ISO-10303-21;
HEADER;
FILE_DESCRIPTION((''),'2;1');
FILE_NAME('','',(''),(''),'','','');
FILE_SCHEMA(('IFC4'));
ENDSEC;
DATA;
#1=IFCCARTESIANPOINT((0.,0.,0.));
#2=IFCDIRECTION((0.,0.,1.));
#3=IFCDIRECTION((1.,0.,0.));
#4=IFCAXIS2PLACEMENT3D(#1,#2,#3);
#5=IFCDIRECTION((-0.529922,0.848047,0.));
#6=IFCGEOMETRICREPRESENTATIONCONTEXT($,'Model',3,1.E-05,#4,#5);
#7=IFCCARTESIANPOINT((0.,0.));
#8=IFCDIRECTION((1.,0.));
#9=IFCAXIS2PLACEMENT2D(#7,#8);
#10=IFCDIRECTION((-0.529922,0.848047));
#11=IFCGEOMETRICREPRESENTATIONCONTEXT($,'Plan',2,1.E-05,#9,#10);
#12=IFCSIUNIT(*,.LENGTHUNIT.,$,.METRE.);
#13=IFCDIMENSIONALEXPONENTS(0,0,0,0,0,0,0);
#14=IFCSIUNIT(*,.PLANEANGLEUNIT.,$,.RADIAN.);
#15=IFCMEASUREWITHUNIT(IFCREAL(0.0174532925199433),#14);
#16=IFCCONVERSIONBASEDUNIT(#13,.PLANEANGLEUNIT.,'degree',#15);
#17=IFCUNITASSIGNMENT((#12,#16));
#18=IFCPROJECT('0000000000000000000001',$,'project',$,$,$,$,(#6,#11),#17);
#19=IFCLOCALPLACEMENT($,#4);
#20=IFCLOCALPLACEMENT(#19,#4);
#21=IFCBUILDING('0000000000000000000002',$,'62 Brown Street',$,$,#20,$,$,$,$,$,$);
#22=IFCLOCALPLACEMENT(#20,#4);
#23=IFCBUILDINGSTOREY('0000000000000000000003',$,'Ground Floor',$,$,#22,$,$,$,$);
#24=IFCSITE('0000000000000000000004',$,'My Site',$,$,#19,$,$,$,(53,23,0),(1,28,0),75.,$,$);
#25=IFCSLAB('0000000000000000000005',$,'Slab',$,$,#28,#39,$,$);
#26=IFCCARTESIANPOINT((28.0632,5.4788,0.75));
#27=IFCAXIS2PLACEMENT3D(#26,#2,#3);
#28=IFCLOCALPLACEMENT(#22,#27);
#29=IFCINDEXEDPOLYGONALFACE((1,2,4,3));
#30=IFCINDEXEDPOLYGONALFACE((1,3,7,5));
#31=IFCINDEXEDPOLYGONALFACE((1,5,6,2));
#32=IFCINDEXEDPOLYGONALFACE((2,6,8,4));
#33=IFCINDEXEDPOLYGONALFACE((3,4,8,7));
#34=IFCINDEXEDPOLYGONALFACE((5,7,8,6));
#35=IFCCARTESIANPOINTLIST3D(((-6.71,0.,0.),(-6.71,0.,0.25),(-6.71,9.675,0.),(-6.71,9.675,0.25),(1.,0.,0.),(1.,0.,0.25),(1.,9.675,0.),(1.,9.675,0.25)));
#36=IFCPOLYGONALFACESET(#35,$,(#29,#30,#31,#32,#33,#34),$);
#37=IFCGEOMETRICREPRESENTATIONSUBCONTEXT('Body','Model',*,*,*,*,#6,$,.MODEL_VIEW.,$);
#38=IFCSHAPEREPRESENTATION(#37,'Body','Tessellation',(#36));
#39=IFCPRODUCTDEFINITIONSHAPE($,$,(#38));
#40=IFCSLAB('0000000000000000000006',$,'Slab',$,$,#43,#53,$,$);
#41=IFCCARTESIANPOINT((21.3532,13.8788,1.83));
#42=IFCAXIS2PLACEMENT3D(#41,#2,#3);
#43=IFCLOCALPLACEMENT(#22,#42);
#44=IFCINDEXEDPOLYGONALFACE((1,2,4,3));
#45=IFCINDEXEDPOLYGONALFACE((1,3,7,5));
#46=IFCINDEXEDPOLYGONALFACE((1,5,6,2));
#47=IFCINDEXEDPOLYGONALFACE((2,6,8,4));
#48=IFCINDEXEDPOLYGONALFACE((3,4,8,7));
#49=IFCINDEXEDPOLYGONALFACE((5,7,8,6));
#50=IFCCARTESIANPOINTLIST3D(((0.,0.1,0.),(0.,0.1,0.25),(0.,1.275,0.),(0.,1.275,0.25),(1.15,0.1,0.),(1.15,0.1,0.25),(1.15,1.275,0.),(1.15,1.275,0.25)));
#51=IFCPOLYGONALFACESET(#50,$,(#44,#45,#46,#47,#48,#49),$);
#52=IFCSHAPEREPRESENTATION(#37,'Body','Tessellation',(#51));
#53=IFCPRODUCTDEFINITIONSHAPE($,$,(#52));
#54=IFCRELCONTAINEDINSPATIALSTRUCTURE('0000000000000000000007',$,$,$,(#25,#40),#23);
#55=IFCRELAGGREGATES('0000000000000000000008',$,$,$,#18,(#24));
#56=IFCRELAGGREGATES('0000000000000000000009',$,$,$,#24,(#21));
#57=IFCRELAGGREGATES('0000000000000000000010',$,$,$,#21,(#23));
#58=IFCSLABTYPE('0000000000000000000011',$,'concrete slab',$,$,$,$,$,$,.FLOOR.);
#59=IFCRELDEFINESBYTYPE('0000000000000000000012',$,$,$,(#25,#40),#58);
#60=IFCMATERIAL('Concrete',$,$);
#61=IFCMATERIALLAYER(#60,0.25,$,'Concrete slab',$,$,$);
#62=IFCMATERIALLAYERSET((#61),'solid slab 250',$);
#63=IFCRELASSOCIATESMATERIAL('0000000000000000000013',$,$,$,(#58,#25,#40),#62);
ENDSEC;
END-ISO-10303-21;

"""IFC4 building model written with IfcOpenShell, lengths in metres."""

from ifc_helpers import new_model, entity, si_unit, converted_unit, direction, frame, origin_with_axes, origin_2d_with_axis, place, context, subcontext, project, spatial, indexed_curve, outline, extrude, material, layer, layer_set, layer_usage, type_object, element, save


model = new_model("IFC4")

# Units and contexts
model_context = context("Model", 3, precision=1e-05, world=origin_with_axes(), true_north=direction((-0.529922, 0.848047, 0.0)))
plan_context = context("Plan", 2, precision=1e-05, world=origin_2d_with_axis(), true_north=direction((-0.529922, 0.848047)))
body_context_1 = subcontext(model_context, "Body", "Model", "MODEL_VIEW")
ifc_project = project(units=[si_unit("LENGTHUNIT", "METRE"), converted_unit("PLANEANGLEUNIT", "degree", entity("IfcReal", 0.0174532925199433), si_unit("PLANEANGLEUNIT", "RADIAN"), dimensions=[0, 0, 0, 0, 0, 0, 0])], contexts=[model_context, plan_context])

# Site, building, storey
site_placement = place(None, origin_with_axes())
site = spatial("IfcSite", under=ifc_project, at=site_placement, Name="My Site", RefLatitude=(53, 23, 0), RefLongitude=(1, 28, 0), RefElevation=75.0)
building_placement = place(site_placement, origin_with_axes())
building = spatial("IfcBuilding", under=site, at=building_placement, Name="62 Brown Street")
storey_placement = place(building_placement, origin_with_axes())
storey = spatial("IfcBuildingStorey", under=building, at=storey_placement, Name="Ground Floor")

# Shared definitions
ifc_material_1 = material(Name="Concrete")

# Slabs
ifc_layer_1 = layer(ifc_material_1, 0.25, Name="Concrete slab")
ifc_layer_set_1 = layer_set([ifc_layer_1], Name="solid slab 250")
slab_type = type_object("IfcSlabType", Name="concrete slab", PredefinedType="FLOOR", material=ifc_layer_set_1)
ifc_layer_usage_1 = layer_usage(ifc_layer_set_1, "AXIS3", "POSITIVE", 0.0)
slab_1_placement = place(storey_placement, frame((28.0632, 5.4788, 0.75), z_axis=(0.0, 0.0, 1.0), x_axis=(1.0, 0.0, 0.0)))
element("IfcSlab", 1, at=slab_1_placement, inside=storey, type_object=slab_type, material=ifc_layer_usage_1, Name="Slab", context=body_context_1, shape_type="SweptSolid", body=[
    extrude(outline(indexed_curve([(-6.71, 0.0), (-6.71, 9.675), (1.0, 9.675), (1.0, 0.0), (-6.71, 0.0)])), None, (0.0, 0.0, 1.0), 0.25),
])
ifc_layer_usage_2 = layer_usage(ifc_layer_set_1, "AXIS3", "POSITIVE", 0.0)
slab_2_placement = place(storey_placement, frame((21.3532, 13.8788, 1.83), z_axis=(0.0, 0.0, 1.0), x_axis=(1.0, 0.0, 0.0)))
element("IfcSlab", 2, at=slab_2_placement, inside=storey, type_object=slab_type, material=ifc_layer_usage_2, Name="Slab", context=body_context_1, shape_type="SweptSolid", body=[
    extrude(outline(indexed_curve([(0.0, 1.275), (1.15, 1.275), (1.15, 0.1), (0.0, 0.1), (0.0, 1.275)])), None, (0.0, 0.0, 1.0), 0.25),
])

save(model, "model.ifc")
